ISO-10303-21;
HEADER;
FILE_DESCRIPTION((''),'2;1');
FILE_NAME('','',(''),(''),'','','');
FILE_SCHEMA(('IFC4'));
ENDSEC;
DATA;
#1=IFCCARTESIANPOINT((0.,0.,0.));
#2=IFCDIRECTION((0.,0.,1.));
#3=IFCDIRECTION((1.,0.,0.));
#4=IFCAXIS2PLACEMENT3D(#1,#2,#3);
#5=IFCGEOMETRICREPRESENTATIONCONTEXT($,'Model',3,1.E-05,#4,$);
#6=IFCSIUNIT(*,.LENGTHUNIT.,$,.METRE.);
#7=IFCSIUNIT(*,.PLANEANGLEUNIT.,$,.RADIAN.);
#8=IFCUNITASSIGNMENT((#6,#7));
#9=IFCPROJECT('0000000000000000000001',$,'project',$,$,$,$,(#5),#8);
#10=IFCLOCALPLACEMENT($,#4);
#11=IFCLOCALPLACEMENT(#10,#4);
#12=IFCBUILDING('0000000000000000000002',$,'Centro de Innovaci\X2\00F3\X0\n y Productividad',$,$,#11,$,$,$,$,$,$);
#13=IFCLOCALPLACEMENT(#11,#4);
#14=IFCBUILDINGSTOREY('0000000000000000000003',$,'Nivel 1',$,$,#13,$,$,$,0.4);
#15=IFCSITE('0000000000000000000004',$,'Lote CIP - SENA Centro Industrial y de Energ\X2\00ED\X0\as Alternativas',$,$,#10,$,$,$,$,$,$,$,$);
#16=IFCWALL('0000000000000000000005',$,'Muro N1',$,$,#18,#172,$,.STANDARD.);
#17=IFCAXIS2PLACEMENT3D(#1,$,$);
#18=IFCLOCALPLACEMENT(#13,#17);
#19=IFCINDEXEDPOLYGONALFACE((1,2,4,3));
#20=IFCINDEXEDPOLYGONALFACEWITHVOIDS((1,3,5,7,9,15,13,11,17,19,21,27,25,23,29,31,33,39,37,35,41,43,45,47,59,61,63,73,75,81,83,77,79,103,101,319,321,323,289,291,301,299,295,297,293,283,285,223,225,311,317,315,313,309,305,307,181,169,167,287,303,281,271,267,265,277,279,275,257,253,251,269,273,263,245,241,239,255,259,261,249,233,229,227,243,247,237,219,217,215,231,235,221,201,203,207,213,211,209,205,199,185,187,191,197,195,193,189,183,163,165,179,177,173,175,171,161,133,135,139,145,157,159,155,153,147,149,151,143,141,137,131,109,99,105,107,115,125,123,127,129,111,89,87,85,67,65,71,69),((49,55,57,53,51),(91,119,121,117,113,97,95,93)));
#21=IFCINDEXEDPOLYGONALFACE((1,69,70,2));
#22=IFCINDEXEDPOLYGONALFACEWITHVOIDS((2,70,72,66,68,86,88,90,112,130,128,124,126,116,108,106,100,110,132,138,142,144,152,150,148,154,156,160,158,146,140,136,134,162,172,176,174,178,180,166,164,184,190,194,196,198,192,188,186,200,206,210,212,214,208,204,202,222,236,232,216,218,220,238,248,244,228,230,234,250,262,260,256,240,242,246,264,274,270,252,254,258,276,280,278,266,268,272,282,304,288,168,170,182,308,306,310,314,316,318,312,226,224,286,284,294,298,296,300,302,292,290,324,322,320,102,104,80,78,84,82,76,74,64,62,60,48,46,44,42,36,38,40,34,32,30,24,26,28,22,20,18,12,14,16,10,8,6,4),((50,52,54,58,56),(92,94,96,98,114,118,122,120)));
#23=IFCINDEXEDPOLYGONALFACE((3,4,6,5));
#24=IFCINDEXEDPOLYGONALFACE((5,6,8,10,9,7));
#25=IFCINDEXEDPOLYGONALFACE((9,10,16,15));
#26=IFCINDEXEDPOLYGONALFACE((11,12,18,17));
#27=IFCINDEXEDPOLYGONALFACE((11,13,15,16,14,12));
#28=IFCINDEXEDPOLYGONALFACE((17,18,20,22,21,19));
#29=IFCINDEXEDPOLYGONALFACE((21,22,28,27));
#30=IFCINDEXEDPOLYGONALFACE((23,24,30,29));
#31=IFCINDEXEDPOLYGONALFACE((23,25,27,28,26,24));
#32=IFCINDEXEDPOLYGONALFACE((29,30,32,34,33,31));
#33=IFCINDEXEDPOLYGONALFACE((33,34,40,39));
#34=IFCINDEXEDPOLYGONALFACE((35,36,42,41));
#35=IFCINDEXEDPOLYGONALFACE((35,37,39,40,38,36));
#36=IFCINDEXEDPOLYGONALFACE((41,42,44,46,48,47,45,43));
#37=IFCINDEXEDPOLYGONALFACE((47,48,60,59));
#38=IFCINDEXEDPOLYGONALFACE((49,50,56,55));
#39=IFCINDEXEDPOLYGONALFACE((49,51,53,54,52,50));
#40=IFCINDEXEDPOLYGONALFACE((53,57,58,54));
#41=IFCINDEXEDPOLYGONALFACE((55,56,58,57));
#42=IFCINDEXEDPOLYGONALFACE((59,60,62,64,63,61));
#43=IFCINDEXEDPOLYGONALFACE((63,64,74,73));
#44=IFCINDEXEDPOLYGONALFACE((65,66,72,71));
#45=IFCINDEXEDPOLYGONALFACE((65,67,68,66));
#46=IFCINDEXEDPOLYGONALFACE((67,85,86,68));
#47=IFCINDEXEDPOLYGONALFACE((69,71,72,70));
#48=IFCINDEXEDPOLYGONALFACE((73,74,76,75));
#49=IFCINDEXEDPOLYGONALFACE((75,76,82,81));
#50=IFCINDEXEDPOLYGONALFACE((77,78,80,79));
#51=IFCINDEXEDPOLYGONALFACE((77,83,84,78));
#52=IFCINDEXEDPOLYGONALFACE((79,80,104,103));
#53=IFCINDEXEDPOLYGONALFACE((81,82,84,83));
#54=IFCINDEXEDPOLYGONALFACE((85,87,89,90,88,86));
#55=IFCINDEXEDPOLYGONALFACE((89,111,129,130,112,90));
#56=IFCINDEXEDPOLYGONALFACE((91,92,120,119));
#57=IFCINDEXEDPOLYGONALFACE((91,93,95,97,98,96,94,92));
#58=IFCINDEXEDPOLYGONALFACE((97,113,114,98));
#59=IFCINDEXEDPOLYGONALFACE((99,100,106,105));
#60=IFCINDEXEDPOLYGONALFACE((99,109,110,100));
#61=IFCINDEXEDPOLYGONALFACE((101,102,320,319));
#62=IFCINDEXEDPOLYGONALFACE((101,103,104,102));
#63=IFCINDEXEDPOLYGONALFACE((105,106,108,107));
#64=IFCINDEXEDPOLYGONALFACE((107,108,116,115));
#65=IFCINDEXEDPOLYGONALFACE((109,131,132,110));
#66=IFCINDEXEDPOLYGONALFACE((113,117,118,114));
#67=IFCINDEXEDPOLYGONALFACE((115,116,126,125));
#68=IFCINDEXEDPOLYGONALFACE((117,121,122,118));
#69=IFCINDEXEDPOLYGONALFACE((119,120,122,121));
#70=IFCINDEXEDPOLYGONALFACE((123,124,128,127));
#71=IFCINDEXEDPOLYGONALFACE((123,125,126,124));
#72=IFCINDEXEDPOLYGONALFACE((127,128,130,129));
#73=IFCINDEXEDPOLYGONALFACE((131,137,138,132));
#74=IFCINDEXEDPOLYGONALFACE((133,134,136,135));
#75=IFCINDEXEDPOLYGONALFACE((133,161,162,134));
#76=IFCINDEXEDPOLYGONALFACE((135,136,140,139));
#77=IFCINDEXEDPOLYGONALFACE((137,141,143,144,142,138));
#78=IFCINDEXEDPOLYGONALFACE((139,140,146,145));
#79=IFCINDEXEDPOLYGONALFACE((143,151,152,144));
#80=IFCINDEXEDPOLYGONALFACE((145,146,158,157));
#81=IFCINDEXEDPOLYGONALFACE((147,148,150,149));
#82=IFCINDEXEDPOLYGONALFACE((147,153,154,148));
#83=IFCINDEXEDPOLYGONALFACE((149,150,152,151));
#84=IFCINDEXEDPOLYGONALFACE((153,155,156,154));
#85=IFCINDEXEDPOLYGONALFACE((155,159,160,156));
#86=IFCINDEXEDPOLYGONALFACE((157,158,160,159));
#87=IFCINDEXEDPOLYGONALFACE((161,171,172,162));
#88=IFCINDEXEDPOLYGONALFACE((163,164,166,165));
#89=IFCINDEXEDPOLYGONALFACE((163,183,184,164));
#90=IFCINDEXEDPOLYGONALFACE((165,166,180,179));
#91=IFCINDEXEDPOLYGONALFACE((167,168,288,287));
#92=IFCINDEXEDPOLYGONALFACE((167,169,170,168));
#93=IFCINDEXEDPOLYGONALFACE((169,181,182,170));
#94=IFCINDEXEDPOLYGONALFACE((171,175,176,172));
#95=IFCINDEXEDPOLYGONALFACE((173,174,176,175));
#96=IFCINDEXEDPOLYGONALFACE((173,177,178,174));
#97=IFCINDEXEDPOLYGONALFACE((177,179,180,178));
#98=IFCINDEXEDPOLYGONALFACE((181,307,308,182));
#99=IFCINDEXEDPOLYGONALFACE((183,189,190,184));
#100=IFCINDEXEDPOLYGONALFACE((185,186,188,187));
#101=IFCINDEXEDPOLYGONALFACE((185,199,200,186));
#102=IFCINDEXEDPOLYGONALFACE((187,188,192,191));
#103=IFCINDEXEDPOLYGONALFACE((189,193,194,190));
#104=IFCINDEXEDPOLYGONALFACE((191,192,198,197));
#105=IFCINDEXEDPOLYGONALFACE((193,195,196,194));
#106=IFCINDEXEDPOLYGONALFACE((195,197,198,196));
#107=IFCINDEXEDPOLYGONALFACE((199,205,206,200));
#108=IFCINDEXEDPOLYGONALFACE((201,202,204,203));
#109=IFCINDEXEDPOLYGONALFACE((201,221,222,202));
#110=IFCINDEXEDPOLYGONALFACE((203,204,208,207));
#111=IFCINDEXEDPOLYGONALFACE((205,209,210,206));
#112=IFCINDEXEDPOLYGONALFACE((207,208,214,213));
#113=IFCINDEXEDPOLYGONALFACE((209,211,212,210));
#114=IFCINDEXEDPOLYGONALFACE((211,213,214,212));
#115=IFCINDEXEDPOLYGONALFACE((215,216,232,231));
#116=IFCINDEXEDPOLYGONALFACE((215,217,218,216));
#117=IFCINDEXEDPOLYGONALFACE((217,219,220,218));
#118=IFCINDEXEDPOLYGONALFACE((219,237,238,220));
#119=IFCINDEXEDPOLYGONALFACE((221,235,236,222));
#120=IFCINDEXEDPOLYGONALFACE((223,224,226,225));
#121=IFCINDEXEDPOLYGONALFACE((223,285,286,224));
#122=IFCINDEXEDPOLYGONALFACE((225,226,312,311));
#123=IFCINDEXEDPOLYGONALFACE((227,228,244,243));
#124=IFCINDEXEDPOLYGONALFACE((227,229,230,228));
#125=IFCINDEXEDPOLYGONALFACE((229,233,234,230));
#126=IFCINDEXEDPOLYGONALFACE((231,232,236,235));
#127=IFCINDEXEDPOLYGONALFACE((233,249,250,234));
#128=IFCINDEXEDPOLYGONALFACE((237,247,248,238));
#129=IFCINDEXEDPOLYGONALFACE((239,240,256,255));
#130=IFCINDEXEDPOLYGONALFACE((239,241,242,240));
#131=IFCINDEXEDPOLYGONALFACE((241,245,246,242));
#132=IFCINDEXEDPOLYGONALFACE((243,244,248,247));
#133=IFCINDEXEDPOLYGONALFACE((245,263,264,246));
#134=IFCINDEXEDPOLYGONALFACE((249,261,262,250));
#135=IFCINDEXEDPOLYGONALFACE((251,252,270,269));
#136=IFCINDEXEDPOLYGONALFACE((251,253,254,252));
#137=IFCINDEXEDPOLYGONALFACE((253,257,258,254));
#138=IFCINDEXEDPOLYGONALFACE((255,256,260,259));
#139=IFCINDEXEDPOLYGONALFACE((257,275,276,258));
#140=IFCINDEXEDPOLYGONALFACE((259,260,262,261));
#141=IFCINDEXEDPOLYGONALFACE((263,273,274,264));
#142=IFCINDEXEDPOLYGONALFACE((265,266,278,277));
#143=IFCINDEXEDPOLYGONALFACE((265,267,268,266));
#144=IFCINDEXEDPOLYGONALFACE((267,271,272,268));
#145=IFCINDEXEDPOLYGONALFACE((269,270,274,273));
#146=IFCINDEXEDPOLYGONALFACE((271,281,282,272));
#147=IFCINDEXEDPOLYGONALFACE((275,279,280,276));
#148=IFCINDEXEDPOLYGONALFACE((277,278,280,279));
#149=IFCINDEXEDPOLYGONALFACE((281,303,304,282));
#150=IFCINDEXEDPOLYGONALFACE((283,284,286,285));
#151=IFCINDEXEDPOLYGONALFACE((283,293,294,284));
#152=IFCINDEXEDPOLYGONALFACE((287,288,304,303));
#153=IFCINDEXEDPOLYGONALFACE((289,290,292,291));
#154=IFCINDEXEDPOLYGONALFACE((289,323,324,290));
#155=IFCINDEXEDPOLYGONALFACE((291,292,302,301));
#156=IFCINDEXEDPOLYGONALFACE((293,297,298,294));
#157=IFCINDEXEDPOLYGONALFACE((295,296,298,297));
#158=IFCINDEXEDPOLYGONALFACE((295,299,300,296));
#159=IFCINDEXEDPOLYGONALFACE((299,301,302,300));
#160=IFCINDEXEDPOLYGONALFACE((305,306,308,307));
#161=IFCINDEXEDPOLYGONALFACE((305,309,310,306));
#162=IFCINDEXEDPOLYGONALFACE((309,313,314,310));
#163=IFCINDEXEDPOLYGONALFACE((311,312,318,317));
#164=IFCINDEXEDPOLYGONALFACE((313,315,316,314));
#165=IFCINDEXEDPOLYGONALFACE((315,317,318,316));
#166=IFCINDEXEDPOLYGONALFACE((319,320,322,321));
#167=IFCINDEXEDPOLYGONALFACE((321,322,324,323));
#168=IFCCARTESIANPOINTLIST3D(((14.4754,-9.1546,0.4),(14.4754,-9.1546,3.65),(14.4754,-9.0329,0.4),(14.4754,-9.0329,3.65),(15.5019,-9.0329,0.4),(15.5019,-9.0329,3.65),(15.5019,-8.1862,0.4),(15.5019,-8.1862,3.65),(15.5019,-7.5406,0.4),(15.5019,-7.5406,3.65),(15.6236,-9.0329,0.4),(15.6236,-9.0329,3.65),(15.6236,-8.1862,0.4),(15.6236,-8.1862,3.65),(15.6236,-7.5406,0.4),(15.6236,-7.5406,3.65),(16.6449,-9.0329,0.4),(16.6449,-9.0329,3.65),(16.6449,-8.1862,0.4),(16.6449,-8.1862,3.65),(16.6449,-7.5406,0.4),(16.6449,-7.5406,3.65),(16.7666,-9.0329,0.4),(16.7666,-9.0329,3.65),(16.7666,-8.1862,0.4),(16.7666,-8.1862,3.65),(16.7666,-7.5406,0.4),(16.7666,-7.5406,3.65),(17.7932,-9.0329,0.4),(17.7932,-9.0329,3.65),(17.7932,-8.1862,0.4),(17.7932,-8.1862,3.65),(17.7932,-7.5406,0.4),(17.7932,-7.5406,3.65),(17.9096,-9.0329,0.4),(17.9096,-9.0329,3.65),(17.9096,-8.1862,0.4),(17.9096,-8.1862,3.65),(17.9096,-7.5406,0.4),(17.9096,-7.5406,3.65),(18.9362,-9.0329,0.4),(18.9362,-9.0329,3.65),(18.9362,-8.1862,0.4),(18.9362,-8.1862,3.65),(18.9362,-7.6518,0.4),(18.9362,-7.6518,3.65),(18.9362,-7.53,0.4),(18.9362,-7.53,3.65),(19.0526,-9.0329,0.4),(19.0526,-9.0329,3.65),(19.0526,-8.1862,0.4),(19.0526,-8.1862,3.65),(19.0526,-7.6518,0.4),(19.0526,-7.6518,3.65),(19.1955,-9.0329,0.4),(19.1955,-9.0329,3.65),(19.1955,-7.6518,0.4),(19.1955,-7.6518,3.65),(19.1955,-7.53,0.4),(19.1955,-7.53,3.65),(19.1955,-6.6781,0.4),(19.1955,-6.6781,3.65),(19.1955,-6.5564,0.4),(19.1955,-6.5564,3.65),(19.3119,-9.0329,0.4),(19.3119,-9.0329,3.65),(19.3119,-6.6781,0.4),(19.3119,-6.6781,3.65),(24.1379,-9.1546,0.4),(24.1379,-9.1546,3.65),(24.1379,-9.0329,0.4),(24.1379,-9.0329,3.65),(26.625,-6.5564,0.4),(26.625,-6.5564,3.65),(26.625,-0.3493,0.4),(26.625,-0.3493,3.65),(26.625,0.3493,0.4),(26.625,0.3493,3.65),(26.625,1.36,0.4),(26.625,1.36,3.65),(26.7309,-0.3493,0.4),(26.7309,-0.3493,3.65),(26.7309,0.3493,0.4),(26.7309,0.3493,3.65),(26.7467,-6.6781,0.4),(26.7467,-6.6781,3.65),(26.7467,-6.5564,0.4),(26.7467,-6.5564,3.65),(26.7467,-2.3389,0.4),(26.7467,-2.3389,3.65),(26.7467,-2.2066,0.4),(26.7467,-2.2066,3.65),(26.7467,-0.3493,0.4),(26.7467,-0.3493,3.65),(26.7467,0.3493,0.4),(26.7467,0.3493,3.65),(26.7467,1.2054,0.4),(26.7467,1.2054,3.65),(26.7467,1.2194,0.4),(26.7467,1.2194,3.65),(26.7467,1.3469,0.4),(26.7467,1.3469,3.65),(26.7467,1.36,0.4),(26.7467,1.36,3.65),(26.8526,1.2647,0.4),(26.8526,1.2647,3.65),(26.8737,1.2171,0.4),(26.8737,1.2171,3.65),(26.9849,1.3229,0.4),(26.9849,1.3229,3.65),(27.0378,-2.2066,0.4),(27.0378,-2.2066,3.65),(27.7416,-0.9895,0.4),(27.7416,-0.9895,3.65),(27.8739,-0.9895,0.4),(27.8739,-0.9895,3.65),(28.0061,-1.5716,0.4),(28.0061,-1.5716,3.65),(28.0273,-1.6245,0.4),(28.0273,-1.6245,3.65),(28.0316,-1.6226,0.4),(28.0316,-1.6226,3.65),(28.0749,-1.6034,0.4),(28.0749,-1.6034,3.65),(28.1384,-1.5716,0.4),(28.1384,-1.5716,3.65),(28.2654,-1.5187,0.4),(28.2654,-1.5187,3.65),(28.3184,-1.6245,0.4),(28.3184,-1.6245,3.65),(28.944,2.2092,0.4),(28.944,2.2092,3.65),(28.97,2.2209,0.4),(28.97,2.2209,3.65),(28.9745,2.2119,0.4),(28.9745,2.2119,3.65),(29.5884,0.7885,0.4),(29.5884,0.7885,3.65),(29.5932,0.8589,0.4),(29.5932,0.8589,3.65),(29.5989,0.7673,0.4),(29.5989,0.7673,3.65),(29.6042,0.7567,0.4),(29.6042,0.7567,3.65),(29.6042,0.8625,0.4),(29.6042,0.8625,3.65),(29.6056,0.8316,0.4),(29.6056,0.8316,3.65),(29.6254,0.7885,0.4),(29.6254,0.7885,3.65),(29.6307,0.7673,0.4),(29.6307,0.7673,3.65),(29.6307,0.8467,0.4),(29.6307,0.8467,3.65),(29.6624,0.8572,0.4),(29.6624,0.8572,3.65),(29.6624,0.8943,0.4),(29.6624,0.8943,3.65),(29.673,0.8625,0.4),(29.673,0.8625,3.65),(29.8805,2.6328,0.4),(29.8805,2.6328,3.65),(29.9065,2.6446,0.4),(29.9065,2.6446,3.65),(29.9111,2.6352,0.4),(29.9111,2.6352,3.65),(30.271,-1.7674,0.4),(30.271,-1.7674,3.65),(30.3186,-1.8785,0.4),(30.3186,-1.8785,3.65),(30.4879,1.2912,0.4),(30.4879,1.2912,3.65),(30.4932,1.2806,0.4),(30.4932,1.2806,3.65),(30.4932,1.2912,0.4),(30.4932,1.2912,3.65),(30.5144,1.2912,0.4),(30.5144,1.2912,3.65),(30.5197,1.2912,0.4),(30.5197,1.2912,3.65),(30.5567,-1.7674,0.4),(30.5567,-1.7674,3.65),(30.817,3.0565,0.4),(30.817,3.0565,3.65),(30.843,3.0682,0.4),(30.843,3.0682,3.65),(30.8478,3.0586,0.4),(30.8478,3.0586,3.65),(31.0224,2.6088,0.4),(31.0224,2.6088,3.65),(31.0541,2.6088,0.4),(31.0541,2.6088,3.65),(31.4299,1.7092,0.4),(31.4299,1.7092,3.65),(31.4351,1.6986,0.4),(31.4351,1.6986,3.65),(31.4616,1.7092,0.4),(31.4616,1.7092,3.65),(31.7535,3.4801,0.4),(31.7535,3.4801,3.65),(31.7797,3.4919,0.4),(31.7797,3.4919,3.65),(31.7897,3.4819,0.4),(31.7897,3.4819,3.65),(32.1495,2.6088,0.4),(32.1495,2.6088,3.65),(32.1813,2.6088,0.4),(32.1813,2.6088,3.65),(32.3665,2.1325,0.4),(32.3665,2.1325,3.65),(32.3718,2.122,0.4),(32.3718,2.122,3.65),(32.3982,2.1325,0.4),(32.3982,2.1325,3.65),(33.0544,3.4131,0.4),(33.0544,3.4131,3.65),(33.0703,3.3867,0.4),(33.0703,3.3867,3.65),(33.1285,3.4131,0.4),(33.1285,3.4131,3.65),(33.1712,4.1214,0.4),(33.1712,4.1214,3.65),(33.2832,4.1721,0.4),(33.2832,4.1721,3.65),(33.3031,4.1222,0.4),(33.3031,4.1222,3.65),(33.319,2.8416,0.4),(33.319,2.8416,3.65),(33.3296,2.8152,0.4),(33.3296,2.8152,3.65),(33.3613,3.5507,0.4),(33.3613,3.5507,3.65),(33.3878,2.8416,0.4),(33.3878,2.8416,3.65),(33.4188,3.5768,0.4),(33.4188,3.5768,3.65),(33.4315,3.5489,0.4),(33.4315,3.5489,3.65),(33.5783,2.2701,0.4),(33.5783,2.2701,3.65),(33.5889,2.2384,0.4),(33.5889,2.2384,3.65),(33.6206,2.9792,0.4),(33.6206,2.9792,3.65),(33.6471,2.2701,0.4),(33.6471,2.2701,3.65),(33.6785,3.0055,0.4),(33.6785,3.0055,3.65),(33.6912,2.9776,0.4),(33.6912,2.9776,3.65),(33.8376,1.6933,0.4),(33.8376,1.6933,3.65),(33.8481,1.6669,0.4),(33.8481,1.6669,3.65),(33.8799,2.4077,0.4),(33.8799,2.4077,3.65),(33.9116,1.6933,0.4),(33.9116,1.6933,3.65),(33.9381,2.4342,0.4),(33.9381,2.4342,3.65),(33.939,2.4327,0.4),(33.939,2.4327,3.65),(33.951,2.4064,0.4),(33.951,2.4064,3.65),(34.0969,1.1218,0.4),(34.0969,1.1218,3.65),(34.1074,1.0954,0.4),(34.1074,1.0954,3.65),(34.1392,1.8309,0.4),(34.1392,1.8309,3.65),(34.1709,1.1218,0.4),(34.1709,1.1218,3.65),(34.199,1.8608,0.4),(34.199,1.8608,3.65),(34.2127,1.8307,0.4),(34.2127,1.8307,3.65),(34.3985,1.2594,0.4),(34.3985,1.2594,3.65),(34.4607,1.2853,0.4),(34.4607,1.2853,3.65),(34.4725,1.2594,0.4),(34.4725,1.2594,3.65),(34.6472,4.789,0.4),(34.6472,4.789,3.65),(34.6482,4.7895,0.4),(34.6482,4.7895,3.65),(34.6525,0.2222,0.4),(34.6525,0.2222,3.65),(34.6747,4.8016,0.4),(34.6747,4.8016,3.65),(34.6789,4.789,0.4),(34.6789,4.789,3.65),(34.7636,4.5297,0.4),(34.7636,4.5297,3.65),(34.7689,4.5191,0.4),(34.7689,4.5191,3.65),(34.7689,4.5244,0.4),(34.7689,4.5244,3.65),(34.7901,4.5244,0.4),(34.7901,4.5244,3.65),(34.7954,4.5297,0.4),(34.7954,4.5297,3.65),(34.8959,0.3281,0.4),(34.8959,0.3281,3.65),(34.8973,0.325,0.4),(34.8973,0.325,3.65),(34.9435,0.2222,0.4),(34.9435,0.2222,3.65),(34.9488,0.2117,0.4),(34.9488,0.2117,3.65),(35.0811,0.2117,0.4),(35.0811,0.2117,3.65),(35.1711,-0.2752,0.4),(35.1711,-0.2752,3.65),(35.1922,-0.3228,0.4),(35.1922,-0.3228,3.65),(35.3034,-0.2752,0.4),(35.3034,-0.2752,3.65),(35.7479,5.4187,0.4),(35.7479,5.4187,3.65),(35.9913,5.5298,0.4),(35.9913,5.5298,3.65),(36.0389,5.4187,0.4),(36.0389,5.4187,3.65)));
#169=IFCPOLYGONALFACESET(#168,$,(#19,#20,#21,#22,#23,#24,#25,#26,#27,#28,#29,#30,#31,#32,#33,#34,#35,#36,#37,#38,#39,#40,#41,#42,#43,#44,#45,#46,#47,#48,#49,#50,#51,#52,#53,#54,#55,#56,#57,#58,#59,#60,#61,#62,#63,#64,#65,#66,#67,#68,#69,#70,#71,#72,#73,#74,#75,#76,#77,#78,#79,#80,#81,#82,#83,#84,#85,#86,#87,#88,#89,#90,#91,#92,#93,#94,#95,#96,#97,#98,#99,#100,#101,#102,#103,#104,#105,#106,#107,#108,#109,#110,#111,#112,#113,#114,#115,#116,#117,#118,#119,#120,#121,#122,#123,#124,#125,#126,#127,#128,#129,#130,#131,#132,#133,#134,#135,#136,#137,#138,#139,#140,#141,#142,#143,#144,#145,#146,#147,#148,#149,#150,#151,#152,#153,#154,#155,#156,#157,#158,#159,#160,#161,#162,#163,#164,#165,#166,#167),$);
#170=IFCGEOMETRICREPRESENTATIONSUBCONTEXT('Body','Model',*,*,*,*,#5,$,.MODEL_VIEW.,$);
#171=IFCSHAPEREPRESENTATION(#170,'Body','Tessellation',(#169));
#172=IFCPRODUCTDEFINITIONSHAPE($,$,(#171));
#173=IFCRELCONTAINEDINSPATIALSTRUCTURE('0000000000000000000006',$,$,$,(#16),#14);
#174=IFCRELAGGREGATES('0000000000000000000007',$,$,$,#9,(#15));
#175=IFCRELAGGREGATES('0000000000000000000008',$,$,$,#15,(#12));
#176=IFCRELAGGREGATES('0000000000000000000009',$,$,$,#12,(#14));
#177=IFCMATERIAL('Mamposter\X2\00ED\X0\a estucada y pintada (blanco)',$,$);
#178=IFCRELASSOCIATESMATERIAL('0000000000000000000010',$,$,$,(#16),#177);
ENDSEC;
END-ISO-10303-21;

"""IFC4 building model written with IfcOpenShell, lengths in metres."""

from ifc_helpers import new_model, si_unit, frame, origin_with_axes, place, context, subcontext, project, spatial, polyline, outline, extrude, material, element, save


model = new_model("IFC4")

# Units and contexts
model_context = context("Model", 3, precision=1e-05, world=origin_with_axes())
body_context = subcontext(model_context, "Body", "Model", "MODEL_VIEW")
ifc_project = project(units=[si_unit("LENGTHUNIT", "METRE"), si_unit("PLANEANGLEUNIT", "RADIAN")], contexts=[model_context])

# Site, building, storey
site_placement = place(None, origin_with_axes())
site = spatial("IfcSite", under=ifc_project, at=site_placement, Name="Lote CIP - SENA Centro Industrial y de Energías Alternativas")
building_placement = place(site_placement, origin_with_axes())
building = spatial("IfcBuilding", under=site, at=building_placement, Name="Centro de Innovación y Productividad")
storey_placement = place(building_placement, origin_with_axes())
storey = spatial("IfcBuildingStorey", under=building, at=storey_placement, Name="Nivel 1", Elevation=0.4)

# Wall
ifc_material = material(Name="Mampostería estucada y pintada (blanco)")
wall_1_placement = place(storey_placement, origin_with_axes())
element("IfcWall", 1, at=wall_1_placement, inside=storey, material=ifc_material, Name="Muro N1", PredefinedType="STANDARD", context=body_context, shape_type="SweptSolid", body=[
    extrude(outline(polyline([(16.7666, -8.1862), (16.7666, -9.0329), (17.7932, -9.0329), (17.7932, -8.1862), (17.7932, -7.5406), (17.9096, -7.5406), (17.9096, -8.1862), (17.9096, -9.0329), (18.9362, -9.0329), (18.9362, -8.1862), (18.9362, -7.6518), (18.9362, -7.53), (19.1955, -7.53), (19.1955, -6.6781), (19.1955, -6.5564), (26.625, -6.5564), (26.625, -0.3493), (26.7309, -0.3493), (26.7309, 0.3493), (26.625, 0.3493), (26.625, 1.36), (26.7467, 1.36), (26.7467, 1.3469), (35.7479, 5.4187), (35.9913, 5.5298), (36.0389, 5.4187), (34.6747, 4.8016), (34.6789, 4.789), (34.7954, 4.5297), (34.7901, 4.5244), (34.7689, 4.5191), (34.7689, 4.5244), (34.7636, 4.5297), (34.6472, 4.789), (34.6482, 4.7895), (33.2832, 4.1721), (33.3031, 4.1222), (35.0811, 0.2117), (35.3034, -0.2752), (35.1922, -0.3228), (35.1711, -0.2752), (34.9488, 0.2117), (34.8973, 0.325), (34.9435, 0.2222), (30.5567, -1.7674), (30.3186, -1.8785), (30.271, -1.7674), (34.6525, 0.2222), (34.8959, 0.3281), (34.4725, 1.2594), (34.1709, 1.1218), (34.1074, 1.0954), (34.0969, 1.1218), (34.3985, 1.2594), (34.4607, 1.2853), (34.2127, 1.8307), (33.9116, 1.6933), (33.8481, 1.6669), (33.8376, 1.6933), (34.1392, 1.8309), (34.199, 1.8608), (33.951, 2.4064), (33.6471, 2.2701), (33.5889, 2.2384), (33.5783, 2.2701), (33.8799, 2.4077), (33.9381, 2.4342), (33.939, 2.4327), (33.6912, 2.9776), (33.3878, 2.8416), (33.3296, 2.8152), (33.319, 2.8416), (33.6206, 2.9792), (33.6785, 3.0055), (33.4315, 3.5489), (33.1285, 3.4131), (33.0703, 3.3867), (33.0544, 3.4131), (33.3613, 3.5507), (33.4188, 3.5768), (33.1712, 4.1214), (31.7797, 3.4919), (31.7897, 3.4819), (32.1813, 2.6088), (32.3982, 2.1325), (32.3718, 2.122), (32.3665, 2.1325), (32.1495, 2.6088), (31.7535, 3.4801), (30.843, 3.0682), (30.8478, 3.0586), (31.0541, 2.6088), (31.4616, 1.7092), (31.4351, 1.6986), (31.4299, 1.7092), (31.0224, 2.6088), (30.817, 3.0565), (29.9065, 2.6446), (29.9111, 2.6352), (30.5197, 1.2912), (30.5144, 1.2912), (30.4932, 1.2806), (30.4932, 1.2912), (30.4879, 1.2912), (29.8805, 2.6328), (28.97, 2.2209), (28.9745, 2.2119), (29.5932, 0.8589), (29.6042, 0.8625), (29.6624, 0.8943), (29.673, 0.8625), (29.6624, 0.8572), (29.6307, 0.8467), (29.6056, 0.8316), (29.6254, 0.7885), (29.6307, 0.7673), (29.6042, 0.7567), (29.5989, 0.7673), (29.5884, 0.7885), (28.944, 2.2092), (26.9849, 1.3229), (26.7467, 1.2194), (26.7467, 1.2194), (26.8526, 1.2647), (26.8737, 1.2171), (27.8739, -0.9895), (28.1384, -1.5716), (28.0749, -1.6034), (28.2654, -1.5187), (28.3184, -1.6245), (27.0378, -2.2066), (26.7467, -2.3389), (26.7467, -6.5564), (26.7467, -6.6781), (19.3119, -6.6781), (19.3119, -9.0329), (24.1379, -9.0329), (24.1379, -9.1546), (14.4754, -9.1546), (14.4754, -9.0329), (15.5019, -9.0329), (15.5019, -8.1862), (15.5019, -7.5406), (15.6236, -7.5406), (15.6236, -8.1862), (15.6236, -9.0329), (16.6449, -9.0329), (16.6449, -8.1862), (16.6449, -7.5406), (16.7666, -7.5406), (16.7666, -8.1862)]), holes=[polyline([(26.7467, 1.2054), (26.7467, 0.3493), (26.7467, -0.3493), (26.7467, -2.2066), (28.0273, -1.6245), (28.0316, -1.6226), (28.0061, -1.5716), (27.7416, -0.9895), (26.7467, 1.2054)]), polyline([(19.0526, -8.1862), (19.0526, -9.0329), (19.1955, -9.0329), (19.1955, -7.6518), (19.0526, -7.6518), (19.0526, -8.1862)])]), frame((0.0, 0.0, 0.4)), (0.0, 0.0, 1.0), 3.25),
])

save(model, "model.ifc")
